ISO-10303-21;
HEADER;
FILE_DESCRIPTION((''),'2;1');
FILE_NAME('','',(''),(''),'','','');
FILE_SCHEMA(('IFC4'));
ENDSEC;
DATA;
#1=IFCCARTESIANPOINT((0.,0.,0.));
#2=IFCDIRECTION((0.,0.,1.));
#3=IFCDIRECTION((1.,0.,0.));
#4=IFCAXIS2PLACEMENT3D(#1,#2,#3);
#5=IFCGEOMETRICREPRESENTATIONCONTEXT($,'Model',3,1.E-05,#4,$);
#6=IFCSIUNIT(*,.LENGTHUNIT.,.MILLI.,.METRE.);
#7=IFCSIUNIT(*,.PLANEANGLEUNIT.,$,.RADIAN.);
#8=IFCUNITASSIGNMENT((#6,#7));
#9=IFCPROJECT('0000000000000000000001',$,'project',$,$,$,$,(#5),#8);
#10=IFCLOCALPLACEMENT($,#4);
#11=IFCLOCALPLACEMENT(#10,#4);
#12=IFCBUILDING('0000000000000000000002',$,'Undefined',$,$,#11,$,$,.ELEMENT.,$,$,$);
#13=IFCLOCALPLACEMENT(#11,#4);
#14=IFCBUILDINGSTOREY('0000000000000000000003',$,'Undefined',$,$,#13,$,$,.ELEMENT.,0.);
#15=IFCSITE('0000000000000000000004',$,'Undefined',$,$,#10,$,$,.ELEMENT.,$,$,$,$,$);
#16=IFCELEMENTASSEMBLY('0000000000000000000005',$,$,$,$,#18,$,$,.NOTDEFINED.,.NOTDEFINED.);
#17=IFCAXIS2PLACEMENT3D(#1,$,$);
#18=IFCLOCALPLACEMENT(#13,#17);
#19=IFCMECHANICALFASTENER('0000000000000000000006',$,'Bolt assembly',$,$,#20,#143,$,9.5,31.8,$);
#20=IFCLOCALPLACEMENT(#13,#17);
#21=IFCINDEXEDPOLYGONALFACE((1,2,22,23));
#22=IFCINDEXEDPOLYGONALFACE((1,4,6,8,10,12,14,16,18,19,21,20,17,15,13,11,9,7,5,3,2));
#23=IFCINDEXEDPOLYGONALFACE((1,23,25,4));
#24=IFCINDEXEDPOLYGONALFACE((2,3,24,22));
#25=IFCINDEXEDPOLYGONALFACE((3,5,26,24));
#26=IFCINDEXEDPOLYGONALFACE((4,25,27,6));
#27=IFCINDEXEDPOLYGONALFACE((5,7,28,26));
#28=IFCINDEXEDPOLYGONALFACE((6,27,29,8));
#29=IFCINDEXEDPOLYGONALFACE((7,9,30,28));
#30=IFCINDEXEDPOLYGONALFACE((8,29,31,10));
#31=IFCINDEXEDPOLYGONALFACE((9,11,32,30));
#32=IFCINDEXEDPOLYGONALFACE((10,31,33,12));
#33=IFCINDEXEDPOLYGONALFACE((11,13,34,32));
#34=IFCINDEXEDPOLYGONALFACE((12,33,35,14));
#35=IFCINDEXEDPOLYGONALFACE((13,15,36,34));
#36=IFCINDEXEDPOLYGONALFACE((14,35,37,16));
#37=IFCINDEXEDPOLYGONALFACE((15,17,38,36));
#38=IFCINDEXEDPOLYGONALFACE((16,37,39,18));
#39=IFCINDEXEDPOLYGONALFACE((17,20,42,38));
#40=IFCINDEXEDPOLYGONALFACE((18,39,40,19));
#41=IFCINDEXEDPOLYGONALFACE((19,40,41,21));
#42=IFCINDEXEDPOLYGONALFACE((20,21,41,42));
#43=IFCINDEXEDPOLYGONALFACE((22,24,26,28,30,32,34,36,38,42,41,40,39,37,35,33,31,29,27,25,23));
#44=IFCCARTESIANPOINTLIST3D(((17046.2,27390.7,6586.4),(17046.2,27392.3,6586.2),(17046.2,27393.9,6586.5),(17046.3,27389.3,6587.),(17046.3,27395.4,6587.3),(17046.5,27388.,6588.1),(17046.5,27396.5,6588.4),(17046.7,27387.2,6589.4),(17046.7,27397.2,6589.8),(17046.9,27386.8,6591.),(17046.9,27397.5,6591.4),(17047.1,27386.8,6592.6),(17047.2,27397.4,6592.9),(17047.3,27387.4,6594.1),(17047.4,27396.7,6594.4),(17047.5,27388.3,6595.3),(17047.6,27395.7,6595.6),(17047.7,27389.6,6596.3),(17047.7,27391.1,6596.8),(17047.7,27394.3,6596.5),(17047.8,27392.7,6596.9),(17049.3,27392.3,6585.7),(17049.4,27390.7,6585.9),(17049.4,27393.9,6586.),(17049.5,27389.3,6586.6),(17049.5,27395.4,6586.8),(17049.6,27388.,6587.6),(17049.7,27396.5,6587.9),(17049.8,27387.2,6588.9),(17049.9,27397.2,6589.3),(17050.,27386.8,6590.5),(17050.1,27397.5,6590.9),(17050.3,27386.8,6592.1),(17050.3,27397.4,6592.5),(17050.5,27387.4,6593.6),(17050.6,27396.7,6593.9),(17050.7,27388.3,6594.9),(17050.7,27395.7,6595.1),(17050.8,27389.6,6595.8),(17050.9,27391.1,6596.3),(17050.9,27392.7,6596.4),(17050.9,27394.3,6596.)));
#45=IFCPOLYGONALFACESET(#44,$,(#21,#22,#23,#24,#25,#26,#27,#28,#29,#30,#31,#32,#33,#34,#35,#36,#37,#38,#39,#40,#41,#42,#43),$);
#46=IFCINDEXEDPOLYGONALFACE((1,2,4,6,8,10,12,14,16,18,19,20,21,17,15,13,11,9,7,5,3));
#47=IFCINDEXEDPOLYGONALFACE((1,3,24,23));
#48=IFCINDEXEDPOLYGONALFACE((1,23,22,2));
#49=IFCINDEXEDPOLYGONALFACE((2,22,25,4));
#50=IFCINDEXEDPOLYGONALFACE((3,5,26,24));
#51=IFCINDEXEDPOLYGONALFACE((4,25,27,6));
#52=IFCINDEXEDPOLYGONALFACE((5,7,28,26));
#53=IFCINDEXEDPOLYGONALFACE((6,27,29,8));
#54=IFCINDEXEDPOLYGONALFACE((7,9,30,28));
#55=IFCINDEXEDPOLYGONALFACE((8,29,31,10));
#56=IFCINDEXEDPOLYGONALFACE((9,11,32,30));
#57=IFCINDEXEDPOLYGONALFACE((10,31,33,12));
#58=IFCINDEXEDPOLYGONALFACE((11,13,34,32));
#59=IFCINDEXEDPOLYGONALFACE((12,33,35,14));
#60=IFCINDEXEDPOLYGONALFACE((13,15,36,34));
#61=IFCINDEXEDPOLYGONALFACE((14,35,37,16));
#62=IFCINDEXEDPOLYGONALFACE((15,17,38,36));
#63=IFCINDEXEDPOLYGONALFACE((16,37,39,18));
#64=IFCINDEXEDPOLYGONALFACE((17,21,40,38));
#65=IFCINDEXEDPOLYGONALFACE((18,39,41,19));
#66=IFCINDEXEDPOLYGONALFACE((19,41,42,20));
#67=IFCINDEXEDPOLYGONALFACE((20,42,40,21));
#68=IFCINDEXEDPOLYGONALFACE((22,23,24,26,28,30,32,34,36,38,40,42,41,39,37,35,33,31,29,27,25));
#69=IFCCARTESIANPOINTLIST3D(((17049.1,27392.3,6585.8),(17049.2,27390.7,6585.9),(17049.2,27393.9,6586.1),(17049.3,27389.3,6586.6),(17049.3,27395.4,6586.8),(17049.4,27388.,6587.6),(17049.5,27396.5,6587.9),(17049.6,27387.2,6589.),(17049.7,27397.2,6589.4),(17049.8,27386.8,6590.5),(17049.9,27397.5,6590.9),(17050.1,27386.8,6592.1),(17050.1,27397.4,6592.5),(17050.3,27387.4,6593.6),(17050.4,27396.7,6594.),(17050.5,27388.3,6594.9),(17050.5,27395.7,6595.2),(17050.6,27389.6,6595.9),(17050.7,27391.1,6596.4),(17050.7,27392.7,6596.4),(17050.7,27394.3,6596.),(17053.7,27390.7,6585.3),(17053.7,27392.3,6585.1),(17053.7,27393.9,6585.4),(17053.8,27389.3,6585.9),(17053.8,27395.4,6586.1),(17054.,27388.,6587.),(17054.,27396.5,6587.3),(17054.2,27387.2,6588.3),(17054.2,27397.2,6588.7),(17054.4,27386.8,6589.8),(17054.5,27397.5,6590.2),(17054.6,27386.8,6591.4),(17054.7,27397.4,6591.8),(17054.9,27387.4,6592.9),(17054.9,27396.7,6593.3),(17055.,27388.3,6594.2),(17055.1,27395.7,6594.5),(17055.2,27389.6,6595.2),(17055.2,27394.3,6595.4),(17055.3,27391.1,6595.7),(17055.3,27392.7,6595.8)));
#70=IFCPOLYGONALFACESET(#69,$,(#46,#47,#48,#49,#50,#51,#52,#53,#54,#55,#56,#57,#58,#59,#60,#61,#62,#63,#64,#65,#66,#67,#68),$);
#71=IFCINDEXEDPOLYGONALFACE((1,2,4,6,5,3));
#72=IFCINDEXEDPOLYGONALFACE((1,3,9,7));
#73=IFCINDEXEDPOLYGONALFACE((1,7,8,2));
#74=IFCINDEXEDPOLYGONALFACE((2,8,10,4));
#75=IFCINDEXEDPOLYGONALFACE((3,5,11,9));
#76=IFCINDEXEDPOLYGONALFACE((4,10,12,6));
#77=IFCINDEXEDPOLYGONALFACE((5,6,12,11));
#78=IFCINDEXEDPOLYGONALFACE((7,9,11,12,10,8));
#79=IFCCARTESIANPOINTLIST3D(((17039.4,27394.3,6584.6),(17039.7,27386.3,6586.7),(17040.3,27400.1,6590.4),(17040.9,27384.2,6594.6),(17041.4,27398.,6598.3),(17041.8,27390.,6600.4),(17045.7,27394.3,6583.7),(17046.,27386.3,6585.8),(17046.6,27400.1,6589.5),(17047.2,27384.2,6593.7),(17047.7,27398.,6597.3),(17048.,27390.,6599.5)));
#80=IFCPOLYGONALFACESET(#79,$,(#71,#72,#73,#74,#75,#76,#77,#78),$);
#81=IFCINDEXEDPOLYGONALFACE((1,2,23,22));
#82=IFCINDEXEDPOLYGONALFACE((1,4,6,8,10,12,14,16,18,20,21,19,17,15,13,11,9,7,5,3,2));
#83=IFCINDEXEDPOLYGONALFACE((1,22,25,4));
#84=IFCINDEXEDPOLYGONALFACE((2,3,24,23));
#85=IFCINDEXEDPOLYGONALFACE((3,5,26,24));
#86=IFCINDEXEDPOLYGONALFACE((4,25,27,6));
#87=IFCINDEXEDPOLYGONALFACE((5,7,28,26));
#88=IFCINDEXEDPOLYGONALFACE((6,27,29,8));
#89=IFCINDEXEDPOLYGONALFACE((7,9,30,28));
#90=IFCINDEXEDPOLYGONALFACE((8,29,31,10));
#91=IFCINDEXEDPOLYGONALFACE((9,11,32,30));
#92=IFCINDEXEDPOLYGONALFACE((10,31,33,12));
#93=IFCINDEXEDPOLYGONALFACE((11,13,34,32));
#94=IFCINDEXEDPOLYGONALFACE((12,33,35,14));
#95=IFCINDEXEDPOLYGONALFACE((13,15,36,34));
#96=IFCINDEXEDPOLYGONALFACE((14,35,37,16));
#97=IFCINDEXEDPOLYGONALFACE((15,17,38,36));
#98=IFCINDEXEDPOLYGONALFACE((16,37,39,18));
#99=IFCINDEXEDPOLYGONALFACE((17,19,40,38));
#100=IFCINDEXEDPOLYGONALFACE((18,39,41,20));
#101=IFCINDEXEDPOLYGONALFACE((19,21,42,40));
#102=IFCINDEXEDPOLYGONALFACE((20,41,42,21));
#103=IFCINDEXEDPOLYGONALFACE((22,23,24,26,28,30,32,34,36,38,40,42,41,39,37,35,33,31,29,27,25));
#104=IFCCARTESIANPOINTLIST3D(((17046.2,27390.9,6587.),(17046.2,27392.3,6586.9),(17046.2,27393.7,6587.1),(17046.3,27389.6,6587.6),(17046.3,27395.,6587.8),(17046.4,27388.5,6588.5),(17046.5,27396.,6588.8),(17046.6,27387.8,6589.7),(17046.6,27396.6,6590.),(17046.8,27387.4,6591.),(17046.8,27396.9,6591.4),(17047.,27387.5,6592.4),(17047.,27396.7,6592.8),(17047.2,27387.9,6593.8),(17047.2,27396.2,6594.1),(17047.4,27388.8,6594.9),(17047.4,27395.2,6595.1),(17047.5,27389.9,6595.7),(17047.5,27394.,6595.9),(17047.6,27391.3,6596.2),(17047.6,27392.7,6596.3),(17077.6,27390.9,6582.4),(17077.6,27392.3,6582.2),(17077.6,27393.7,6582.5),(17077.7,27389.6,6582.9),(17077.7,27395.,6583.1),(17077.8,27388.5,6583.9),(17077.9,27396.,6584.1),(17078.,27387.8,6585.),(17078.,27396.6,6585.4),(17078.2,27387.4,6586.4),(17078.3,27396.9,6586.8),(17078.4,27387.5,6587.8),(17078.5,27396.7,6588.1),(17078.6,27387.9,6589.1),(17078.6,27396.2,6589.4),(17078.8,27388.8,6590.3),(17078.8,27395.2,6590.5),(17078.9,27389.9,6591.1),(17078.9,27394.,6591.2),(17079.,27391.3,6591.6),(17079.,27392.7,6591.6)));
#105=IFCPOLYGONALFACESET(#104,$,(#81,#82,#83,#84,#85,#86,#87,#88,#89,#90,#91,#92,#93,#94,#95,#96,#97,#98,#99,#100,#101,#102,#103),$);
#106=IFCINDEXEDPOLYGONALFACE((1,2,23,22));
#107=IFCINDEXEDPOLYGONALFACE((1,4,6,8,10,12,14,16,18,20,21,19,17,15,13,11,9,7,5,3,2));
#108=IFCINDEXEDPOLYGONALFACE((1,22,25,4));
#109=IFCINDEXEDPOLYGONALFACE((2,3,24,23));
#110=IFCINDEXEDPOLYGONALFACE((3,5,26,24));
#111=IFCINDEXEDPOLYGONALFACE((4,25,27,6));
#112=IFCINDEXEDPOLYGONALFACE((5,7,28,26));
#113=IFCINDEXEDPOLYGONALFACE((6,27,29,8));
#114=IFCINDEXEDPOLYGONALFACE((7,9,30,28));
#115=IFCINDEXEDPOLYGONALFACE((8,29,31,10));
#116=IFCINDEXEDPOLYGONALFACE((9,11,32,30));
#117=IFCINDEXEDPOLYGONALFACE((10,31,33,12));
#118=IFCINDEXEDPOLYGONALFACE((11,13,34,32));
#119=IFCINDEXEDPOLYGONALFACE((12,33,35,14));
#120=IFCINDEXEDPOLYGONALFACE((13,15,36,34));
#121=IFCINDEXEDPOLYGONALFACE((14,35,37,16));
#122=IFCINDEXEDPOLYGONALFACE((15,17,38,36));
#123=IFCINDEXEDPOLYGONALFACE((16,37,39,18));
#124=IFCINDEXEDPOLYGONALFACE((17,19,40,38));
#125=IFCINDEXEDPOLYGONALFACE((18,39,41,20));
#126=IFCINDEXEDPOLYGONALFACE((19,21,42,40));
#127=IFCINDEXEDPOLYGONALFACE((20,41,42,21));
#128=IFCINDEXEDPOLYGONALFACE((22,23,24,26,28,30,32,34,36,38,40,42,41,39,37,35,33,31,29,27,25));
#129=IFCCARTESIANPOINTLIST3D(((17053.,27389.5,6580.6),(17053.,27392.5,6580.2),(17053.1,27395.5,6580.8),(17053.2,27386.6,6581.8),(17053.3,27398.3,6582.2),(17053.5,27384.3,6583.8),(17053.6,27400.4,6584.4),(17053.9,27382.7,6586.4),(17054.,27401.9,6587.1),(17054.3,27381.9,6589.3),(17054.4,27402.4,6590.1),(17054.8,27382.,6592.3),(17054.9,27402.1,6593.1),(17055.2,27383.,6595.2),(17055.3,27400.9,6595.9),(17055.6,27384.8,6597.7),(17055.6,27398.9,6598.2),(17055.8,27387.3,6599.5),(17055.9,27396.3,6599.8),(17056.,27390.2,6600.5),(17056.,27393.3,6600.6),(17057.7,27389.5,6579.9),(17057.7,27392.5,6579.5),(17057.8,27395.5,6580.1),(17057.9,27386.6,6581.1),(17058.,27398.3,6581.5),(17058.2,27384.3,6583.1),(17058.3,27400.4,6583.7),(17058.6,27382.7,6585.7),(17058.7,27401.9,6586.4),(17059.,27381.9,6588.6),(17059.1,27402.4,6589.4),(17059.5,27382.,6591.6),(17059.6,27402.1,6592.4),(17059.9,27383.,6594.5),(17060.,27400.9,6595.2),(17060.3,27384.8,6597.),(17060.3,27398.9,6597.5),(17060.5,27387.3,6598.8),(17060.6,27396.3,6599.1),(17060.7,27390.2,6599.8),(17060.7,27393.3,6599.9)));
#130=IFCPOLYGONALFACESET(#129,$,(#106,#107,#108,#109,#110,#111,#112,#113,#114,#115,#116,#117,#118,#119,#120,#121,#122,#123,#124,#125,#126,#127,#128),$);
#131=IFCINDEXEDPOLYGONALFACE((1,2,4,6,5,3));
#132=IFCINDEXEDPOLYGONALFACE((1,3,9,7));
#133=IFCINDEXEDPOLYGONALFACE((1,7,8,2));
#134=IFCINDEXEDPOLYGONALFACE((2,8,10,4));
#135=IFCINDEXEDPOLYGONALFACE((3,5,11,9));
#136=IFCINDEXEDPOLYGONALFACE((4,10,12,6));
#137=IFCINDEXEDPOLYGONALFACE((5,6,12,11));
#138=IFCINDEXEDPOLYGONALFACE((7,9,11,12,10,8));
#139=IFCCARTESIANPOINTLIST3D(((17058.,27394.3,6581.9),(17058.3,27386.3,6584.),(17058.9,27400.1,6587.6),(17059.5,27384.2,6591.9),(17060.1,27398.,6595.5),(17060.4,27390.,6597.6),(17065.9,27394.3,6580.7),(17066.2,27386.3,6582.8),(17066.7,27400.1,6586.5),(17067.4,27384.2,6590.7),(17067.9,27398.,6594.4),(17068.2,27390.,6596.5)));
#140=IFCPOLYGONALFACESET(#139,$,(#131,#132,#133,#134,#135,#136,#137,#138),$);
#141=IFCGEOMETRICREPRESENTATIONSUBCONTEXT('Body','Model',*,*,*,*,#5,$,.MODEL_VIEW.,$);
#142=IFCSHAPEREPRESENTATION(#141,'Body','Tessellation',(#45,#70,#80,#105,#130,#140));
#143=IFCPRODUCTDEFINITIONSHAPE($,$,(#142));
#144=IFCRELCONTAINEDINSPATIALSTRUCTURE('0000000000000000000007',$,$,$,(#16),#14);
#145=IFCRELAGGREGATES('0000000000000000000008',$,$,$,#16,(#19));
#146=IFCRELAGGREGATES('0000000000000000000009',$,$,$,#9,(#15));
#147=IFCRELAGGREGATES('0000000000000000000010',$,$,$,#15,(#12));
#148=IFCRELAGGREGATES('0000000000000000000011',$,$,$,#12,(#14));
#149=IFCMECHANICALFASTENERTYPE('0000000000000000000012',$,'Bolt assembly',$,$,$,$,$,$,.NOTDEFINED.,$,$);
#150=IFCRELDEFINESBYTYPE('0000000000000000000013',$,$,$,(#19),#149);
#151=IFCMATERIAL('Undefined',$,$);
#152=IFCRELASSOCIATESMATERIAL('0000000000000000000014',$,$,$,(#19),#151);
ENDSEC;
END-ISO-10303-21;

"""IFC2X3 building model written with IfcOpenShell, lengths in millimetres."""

from ifc_helpers import new_model, si_unit, frame, origin_with_axes, origin_2d_with_axis, place, context, subcontext, project, spatial, polyline, circle, outline, extrude, source, transform, mapped, material, type_object, element, aggregate, save


model = new_model("IFC2X3")

# Units and contexts
model_context = context("Model", 3, precision=1e-05, world=origin_with_axes())
body_context = subcontext(model_context, "Body", "Model", "MODEL_VIEW")
ifc_project = project(units=[si_unit("LENGTHUNIT", "METRE", prefix="MILLI"), si_unit("PLANEANGLEUNIT", "RADIAN")], contexts=[model_context])

# Site, building, storey
site_placement = place(None, origin_with_axes())
site = spatial("IfcSite", under=ifc_project, at=site_placement, Name="Undefined", CompositionType="ELEMENT")
building_placement = place(site_placement, origin_with_axes())
building = spatial("IfcBuilding", under=site, at=building_placement, Name="Undefined", CompositionType="ELEMENT")
storey_placement = place(building_placement, origin_with_axes())
storey = spatial("IfcBuildingStorey", under=building, at=storey_placement, Name="Undefined", CompositionType="ELEMENT", Elevation=0.0)

# Element assembly
assembly_1_placement = place(storey_placement, origin_with_axes())
assembly_1 = element("IfcElementAssembly", 1, at=assembly_1_placement, inside=storey, AssemblyPlace="NOTDEFINED", PredefinedType="NOTDEFINED")

# Shared definitions
ifc_material_1 = material(Name="Undefined")
mechanical_fastener_type = type_object("IfcMechanicalFastenerType", Name="Bolt assembly")

# Mechanical fastener
shared_shape_1 = source(origin_with_axes(), body_context, "Body", "SweptSolid", [
    extrude(circle(Radius=5.4, at=origin_2d_with_axis()), frame((0.0, -3.1, 0.0), z_axis=(0.0, 1.0, 0.0), x_axis=(1.0, 0.0, 0.0)), (0.0, 0.0, 1.0), 3.2),
    extrude(circle(Radius=5.4, at=origin_2d_with_axis()), frame((0.0, -0.1, 0.0), z_axis=(0.0, 1.0, 0.0), x_axis=(1.0, 0.0, 0.0)), (0.0, 0.0, 1.0), 4.6),
    extrude(outline(polyline([(7.1, -4.1), (7.1, 4.1), (0.0, 8.2), (-7.1, 4.1), (-7.1, -4.1), (0.0, -8.2), (7.1, -4.1)])), frame((0.0, -9.6, 0.0), z_axis=(0.0, 1.0, 0.0), x_axis=(1.0, 0.0, 0.0)), (0.0, 0.0, 1.0), 6.3),
    extrude(circle(Radius=4.8, at=origin_2d_with_axis()), frame((0.0, -3.2, 0.0), z_axis=(0.0, 1.0, 0.0), x_axis=(1.0, 0.0, 0.0)), (0.0, 0.0, 1.0), 31.8),
    extrude(circle(Radius=10.3, at=origin_2d_with_axis()), frame((0.0, 4.5, 0.0), z_axis=(0.0, 1.0, 0.0), x_axis=(1.0, 0.0, 0.0)), (0.0, 0.0, 1.0), 4.8),
    extrude(outline(polyline([(7.1, -4.1), (7.1, 4.1), (0.0, 8.2), (-7.1, 4.1), (-7.1, -4.1), (0.0, -8.2), (7.1, -4.1)])), frame((0.0, 9.3, 0.0), z_axis=(0.0, 1.0, 0.0), x_axis=(1.0, 0.0, 0.0)), (0.0, 0.0, 1.0), 7.9),
])
mechanical_fastener_1_placement = place(assembly_1_placement, frame((17050.0, 27392.1, 6591.1), z_axis=(0.10338, 0.707107, 0.699509), x_axis=(0.10338, -0.707107, 0.699509)))
mechanical_fastener_1 = element("IfcMechanicalFastener", 2, at=mechanical_fastener_1_placement, type_object=mechanical_fastener_type, material=ifc_material_1, Name="Bolt assembly", NominalDiameter=9.5, NominalLength=31.8, context=body_context, shape_type="MappedRepresentation", body=[
    mapped(shared_shape_1, transform((0.0, 0.0, 0.0))),
])
aggregate(assembly_1, [mechanical_fastener_1])

save(model, "model.ifc")
